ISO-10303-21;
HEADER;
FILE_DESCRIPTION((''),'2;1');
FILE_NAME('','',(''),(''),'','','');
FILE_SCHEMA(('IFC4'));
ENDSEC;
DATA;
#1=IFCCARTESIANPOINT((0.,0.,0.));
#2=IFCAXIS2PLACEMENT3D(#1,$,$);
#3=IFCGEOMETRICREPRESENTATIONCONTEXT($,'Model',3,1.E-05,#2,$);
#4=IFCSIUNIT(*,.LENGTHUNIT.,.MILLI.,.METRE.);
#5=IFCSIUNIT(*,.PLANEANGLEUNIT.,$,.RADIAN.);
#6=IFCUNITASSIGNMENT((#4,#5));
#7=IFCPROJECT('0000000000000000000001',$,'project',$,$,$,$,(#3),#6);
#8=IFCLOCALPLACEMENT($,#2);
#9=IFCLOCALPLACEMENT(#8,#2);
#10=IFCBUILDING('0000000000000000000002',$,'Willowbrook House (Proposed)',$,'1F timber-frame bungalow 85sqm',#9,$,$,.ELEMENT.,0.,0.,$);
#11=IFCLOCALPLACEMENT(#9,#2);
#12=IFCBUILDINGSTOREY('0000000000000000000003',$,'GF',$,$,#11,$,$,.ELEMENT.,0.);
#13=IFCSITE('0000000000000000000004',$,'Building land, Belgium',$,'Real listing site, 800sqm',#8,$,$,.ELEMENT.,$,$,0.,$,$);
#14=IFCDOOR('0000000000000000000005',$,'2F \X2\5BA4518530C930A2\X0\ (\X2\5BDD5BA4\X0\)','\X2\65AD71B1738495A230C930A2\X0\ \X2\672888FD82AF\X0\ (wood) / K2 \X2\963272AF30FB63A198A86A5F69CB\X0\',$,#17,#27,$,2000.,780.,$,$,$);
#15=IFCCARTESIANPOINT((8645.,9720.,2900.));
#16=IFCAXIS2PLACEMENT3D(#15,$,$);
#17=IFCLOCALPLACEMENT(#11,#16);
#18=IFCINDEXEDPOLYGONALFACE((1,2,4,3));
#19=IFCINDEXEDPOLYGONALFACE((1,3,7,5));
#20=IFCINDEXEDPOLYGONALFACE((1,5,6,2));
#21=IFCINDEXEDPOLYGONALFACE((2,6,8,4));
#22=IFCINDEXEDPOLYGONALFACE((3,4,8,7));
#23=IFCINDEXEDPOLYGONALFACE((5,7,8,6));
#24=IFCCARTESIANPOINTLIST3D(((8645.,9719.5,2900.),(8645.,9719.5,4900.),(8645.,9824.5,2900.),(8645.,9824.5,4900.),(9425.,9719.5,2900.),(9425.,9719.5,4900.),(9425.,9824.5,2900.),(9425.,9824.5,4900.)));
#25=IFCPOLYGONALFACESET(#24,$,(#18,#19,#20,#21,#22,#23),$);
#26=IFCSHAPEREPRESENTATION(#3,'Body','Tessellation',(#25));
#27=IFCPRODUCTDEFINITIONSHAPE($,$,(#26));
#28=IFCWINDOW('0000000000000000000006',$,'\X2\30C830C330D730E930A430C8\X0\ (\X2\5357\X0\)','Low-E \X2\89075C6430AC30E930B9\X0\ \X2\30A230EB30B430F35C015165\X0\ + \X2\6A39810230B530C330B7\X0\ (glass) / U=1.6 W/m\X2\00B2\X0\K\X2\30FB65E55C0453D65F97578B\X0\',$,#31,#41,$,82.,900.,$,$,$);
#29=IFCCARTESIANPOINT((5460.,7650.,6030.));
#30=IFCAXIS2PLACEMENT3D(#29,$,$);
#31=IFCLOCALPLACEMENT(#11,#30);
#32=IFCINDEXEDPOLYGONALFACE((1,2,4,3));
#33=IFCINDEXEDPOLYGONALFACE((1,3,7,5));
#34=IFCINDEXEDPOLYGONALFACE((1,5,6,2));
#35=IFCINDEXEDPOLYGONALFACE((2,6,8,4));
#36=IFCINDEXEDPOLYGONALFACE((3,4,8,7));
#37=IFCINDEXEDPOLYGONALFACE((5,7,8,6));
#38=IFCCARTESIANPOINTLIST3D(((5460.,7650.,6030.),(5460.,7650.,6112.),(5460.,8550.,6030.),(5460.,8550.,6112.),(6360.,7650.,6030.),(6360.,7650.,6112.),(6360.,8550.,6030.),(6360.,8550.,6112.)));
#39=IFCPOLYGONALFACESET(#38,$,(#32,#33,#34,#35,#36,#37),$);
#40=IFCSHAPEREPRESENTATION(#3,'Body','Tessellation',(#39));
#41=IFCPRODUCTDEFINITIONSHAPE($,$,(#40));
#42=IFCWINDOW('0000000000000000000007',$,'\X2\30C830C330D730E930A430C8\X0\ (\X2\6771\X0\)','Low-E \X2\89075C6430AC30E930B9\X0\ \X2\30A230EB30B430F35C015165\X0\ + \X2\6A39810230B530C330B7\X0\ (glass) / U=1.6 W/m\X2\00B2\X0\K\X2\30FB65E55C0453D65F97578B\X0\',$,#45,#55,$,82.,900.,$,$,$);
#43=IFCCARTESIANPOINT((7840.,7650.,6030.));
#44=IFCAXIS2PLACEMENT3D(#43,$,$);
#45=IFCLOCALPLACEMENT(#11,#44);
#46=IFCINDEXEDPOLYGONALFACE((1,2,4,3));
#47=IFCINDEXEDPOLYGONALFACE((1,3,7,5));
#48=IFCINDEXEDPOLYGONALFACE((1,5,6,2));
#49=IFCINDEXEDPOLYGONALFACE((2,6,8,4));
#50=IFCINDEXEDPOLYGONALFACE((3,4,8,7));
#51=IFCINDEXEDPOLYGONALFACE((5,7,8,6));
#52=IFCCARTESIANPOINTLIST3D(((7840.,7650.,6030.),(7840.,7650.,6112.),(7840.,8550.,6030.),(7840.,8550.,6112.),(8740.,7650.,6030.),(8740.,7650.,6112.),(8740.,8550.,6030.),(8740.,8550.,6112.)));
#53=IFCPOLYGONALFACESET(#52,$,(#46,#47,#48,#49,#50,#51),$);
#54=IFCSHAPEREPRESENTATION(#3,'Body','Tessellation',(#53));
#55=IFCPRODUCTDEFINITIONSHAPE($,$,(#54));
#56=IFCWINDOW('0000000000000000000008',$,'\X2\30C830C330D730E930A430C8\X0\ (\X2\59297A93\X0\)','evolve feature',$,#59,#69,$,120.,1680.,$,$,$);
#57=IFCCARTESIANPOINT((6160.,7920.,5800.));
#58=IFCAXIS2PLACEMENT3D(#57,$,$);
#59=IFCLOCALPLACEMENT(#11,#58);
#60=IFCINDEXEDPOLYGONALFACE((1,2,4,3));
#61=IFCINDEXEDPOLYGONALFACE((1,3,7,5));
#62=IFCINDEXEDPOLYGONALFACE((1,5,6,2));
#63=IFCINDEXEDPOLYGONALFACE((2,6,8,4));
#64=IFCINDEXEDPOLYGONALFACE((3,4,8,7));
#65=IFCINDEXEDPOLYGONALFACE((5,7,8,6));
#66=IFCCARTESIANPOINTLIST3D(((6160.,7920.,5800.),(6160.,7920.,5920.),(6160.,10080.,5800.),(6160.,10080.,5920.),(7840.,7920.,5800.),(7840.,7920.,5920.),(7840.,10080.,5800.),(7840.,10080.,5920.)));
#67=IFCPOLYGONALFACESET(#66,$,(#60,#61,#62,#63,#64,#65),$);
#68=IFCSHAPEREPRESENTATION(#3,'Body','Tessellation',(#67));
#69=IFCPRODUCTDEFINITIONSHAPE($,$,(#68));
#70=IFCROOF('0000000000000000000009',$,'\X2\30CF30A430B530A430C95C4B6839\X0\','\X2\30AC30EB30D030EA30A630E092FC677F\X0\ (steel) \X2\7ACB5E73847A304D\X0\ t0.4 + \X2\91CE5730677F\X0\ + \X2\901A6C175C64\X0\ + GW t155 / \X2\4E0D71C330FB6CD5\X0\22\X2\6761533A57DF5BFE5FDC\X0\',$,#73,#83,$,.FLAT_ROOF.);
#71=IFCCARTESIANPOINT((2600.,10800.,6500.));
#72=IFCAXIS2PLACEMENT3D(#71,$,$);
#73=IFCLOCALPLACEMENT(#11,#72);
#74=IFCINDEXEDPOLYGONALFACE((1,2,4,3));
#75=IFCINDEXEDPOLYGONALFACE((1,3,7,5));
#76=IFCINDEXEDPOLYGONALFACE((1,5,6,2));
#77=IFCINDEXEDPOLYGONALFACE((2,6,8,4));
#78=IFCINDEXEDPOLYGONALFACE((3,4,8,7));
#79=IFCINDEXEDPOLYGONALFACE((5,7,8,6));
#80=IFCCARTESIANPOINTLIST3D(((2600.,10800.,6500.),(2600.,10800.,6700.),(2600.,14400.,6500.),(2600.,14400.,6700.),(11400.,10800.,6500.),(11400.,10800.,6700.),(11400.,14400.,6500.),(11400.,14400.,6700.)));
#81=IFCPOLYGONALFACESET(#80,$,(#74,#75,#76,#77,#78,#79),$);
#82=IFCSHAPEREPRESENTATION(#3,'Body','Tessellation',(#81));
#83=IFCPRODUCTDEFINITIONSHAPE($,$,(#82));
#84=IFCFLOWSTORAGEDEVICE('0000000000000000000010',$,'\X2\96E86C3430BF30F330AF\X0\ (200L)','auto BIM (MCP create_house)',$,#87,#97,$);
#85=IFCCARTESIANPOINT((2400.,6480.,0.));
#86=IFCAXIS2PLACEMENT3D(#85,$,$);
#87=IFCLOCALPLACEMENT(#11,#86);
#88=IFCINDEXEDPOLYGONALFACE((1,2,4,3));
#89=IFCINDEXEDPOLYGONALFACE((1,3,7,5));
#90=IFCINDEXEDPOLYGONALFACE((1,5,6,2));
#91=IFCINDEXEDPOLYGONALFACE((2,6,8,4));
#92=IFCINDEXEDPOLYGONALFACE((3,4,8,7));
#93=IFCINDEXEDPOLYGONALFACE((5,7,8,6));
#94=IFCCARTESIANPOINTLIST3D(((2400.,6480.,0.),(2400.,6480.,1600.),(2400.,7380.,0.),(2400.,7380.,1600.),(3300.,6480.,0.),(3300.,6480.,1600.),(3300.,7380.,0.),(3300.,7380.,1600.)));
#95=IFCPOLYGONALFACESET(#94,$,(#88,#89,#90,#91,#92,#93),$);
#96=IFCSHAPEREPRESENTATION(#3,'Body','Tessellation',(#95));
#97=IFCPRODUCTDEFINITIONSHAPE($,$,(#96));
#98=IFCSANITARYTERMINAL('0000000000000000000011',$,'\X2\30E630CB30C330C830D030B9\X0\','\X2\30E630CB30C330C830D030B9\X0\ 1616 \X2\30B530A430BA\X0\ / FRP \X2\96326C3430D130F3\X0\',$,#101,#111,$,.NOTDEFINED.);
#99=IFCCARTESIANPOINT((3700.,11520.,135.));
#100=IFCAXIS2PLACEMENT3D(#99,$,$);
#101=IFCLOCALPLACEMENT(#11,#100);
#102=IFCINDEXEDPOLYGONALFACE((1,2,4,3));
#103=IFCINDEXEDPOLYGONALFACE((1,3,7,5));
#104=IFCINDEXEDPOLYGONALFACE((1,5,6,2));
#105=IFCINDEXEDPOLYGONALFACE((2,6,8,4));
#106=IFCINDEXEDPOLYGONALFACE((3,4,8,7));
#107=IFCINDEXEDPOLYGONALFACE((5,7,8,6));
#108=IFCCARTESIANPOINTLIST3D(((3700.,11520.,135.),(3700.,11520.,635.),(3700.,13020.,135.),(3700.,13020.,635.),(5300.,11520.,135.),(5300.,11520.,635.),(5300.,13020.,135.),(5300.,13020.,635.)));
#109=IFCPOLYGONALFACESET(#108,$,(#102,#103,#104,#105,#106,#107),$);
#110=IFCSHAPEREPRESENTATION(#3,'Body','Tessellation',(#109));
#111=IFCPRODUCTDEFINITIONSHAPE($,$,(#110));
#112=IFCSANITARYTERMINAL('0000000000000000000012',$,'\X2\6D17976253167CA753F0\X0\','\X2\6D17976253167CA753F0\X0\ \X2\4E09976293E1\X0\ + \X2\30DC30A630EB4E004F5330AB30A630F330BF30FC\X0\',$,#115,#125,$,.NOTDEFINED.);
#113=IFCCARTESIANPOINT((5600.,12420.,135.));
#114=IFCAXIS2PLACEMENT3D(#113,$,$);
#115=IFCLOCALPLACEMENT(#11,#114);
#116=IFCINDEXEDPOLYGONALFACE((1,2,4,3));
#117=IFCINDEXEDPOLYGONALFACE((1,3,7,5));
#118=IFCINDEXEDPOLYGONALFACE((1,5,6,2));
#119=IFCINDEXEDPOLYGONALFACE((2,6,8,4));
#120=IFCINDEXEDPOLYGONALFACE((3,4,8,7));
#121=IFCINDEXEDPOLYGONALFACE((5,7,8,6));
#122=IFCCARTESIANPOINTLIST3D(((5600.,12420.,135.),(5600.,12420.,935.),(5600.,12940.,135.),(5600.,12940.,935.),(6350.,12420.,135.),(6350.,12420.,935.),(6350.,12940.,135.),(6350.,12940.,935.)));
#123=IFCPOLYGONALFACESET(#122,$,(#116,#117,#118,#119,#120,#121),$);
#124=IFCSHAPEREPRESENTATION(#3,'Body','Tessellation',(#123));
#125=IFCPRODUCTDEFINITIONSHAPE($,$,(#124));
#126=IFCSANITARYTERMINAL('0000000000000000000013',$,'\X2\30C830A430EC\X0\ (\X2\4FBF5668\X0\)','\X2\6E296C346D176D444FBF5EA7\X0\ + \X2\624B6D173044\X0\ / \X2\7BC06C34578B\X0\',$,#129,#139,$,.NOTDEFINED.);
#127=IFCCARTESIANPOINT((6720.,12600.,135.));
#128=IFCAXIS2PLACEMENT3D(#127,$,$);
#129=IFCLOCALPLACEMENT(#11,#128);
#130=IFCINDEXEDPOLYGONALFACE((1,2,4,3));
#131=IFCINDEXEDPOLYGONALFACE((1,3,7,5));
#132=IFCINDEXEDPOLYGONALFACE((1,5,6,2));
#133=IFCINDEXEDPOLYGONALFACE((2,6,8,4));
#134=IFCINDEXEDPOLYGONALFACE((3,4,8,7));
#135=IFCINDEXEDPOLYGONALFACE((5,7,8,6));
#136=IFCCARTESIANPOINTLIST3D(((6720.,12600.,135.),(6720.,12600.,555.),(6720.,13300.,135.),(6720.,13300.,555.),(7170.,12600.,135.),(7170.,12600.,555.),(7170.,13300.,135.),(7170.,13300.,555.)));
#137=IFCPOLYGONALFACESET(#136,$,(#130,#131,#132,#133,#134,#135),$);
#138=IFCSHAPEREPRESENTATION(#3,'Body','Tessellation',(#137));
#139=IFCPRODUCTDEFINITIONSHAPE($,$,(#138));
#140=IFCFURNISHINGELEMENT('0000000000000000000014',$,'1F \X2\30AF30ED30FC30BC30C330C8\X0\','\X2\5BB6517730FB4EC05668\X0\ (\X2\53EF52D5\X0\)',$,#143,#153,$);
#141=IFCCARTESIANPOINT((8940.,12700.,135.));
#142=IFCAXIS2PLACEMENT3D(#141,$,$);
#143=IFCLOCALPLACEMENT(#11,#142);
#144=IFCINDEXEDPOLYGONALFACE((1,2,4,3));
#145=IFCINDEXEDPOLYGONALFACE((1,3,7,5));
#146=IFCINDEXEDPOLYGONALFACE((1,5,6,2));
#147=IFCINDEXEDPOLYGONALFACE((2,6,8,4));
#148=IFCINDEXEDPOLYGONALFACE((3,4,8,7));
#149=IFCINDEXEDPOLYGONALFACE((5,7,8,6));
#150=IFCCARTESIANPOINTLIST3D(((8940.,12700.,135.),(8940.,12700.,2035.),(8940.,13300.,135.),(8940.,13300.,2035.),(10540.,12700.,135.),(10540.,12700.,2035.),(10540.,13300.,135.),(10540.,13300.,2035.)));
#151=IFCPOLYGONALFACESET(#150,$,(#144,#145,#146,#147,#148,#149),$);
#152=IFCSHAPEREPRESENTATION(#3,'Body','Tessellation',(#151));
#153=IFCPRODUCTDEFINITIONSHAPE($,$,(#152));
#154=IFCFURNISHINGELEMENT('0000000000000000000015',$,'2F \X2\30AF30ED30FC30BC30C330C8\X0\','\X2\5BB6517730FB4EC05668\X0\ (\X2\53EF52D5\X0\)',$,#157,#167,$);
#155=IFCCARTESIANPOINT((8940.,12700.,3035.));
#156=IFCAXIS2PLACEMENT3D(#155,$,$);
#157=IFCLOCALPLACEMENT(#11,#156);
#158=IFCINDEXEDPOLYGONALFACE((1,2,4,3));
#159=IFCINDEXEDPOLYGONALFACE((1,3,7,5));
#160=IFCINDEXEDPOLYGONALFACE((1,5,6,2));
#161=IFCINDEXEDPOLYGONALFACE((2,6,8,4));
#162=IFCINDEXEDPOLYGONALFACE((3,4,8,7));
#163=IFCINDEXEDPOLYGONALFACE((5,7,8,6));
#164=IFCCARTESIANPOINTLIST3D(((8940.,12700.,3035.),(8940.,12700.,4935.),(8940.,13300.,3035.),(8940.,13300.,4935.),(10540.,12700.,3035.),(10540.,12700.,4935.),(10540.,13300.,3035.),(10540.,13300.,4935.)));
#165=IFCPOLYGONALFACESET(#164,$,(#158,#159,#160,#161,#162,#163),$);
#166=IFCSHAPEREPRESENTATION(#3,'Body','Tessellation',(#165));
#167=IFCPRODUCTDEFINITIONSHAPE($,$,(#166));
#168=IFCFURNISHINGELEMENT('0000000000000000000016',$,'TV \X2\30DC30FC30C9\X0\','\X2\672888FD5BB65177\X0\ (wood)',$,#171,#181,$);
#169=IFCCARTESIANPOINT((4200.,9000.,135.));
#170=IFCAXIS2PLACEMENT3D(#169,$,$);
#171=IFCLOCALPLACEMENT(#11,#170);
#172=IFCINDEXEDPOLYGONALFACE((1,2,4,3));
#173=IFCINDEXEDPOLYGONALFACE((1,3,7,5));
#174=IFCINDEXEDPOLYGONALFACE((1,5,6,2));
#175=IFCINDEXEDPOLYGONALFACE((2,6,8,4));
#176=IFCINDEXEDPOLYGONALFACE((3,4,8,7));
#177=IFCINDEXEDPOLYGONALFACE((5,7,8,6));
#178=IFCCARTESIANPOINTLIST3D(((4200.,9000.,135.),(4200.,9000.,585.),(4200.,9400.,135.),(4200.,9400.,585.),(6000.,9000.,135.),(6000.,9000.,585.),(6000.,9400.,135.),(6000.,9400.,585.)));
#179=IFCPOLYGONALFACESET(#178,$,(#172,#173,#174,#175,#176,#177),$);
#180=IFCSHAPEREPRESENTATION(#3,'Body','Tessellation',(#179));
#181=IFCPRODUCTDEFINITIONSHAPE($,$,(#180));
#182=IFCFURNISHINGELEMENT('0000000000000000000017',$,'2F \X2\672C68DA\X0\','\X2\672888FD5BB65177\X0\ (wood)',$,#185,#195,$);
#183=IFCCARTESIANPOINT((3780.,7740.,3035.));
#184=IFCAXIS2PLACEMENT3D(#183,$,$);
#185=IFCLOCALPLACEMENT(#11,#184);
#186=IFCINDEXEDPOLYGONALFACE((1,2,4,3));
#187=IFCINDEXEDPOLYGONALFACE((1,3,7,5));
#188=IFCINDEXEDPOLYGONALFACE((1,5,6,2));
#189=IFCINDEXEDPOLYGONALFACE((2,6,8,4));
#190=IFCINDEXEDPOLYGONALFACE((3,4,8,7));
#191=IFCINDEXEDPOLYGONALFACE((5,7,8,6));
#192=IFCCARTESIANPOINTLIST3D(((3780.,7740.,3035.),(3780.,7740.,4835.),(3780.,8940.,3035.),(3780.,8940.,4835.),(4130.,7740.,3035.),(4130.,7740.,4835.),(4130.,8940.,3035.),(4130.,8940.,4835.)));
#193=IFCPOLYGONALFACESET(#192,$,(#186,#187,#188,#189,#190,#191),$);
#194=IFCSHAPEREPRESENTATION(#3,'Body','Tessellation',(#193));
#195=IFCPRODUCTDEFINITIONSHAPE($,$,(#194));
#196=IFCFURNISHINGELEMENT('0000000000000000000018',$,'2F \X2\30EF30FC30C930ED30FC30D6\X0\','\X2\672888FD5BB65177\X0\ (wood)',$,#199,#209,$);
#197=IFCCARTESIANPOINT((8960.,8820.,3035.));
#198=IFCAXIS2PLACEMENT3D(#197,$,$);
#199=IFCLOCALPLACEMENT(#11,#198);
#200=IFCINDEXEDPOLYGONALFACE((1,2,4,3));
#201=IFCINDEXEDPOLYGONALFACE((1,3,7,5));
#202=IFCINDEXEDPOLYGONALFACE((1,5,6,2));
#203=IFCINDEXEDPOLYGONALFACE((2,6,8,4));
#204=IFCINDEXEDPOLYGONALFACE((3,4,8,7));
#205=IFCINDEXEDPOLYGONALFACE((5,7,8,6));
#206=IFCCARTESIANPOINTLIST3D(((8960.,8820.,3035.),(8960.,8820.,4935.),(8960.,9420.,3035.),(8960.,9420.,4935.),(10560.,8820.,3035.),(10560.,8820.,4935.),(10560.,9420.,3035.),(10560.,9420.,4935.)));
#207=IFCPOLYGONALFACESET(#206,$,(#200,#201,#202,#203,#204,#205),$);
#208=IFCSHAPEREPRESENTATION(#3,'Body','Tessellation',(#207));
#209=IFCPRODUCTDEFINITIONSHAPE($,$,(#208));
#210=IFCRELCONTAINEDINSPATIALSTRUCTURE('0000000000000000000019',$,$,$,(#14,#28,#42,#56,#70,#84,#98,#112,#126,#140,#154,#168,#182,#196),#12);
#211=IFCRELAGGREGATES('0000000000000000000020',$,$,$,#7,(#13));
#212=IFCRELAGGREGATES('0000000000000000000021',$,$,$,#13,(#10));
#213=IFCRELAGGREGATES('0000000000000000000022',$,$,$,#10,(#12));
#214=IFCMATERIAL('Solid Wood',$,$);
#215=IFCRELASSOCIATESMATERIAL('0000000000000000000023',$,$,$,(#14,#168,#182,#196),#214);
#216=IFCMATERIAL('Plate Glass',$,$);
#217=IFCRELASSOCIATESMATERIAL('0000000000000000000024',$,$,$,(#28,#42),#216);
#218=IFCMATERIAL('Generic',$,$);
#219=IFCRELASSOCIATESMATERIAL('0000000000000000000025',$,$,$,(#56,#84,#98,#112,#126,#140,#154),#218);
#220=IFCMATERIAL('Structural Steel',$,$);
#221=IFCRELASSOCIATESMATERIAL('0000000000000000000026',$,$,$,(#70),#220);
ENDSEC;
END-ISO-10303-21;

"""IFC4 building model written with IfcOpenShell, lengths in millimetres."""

from ifc_helpers import new_model, si_unit, frame, frame_2d, origin, place, context, project, spatial, rectangle, extrude, material, element, save


model = new_model("IFC4")

# Units and contexts
model_context = context("Model", 3, precision=1e-05, world=origin())
ifc_project = project(units=[si_unit("LENGTHUNIT", "METRE", prefix="MILLI"), si_unit("PLANEANGLEUNIT", "RADIAN")], contexts=[model_context])

# Site, building, storey
site_placement = place(None, origin())
site = spatial("IfcSite", under=ifc_project, at=site_placement, Name="Building land, Belgium", ObjectType="Real listing site, 800sqm", CompositionType="ELEMENT", RefElevation=0.0)
building_placement = place(site_placement, origin())
building = spatial("IfcBuilding", under=site, at=building_placement, Name="Willowbrook House (Proposed)", ObjectType="1F timber-frame bungalow 85sqm", CompositionType="ELEMENT", ElevationOfRefHeight=0.0, ElevationOfTerrain=0.0)
storey_placement = place(building_placement, origin())
storey = spatial("IfcBuildingStorey", under=building, at=storey_placement, Name="GF", CompositionType="ELEMENT", Elevation=0.0)

# Shared definitions
ifc_material_1 = material(Name="Solid Wood")
ifc_material_2 = material(Name="Plate Glass")

# Door
door_1_placement = place(storey_placement, frame((8645.0, 9720.0, 2900.0)))
element("IfcDoor", 1, at=door_1_placement, inside=storey, material=ifc_material_1, Name="2F 室内ドア (寝室)", Description="断熱玄関ドア 木製芯 (wood) / K2 防犯・採風機構", OverallHeight=2000.0, OverallWidth=780.0, context=model_context, shape_type="SweptSolid", body=[
    extrude(rectangle(XDim=780.0, YDim=105.0, at=frame_2d((390.0, 52.0))), frame((8645.0, 9720.0, 2900.0)), (0.0, 0.0, 1.0), 2000.0),
])

# Windows
window_1_placement = place(storey_placement, frame((5460.0, 7650.0, 6030.0)))
element("IfcWindow", 2, at=window_1_placement, inside=storey, material=ifc_material_2, Name="トップライト (南)", Description="Low-E 複層ガラス アルゴン封入 + 樹脂サッシ (glass) / U=1.6 W/m²K・日射取得型", OverallHeight=82.0, OverallWidth=900.0, context=model_context, shape_type="SweptSolid", body=[
    extrude(rectangle(XDim=900.0, YDim=900.0, at=frame_2d((450.0, 450.0))), frame((5460.0, 7650.0, 6030.0)), (0.0, 0.0, 1.0), 82.0),
])
window_2_placement = place(storey_placement, frame((7840.0, 7650.0, 6030.0)))
element("IfcWindow", 3, at=window_2_placement, inside=storey, material=ifc_material_2, Name="トップライト (東)", Description="Low-E 複層ガラス アルゴン封入 + 樹脂サッシ (glass) / U=1.6 W/m²K・日射取得型", OverallHeight=82.0, OverallWidth=900.0, context=model_context, shape_type="SweptSolid", body=[
    extrude(rectangle(XDim=900.0, YDim=900.0, at=frame_2d((450.0, 450.0))), frame((7840.0, 7650.0, 6030.0)), (0.0, 0.0, 1.0), 82.0),
])
ifc_material_3 = material(Name="Generic")
window_3_placement = place(storey_placement, frame((6160.0, 7920.0, 5800.0)))
element("IfcWindow", 4, at=window_3_placement, inside=storey, material=ifc_material_3, Name="トップライト (天窓)", Description="evolve feature", OverallHeight=120.0, OverallWidth=1680.0, context=model_context, shape_type="SweptSolid", body=[
    extrude(rectangle(XDim=1680.0, YDim=2160.0, at=frame_2d((840.0, 1080.0))), frame((6160.0, 7920.0, 5800.0)), (0.0, 0.0, 1.0), 120.0),
])

# Roof
ifc_material_4 = material(Name="Structural Steel")
roof_placement = place(storey_placement, frame((2600.0, 10800.0, 6500.0)))
element("IfcRoof", 5, at=roof_placement, inside=storey, material=ifc_material_4, Name="ハイサイド屋根", Description="ガルバリウム鋼板 (steel) 立平葺き t0.4 + 野地板 + 通気層 + GW t155 / 不燃・法22条区域対応", PredefinedType="FLAT_ROOF", context=model_context, shape_type="SweptSolid", body=[
    extrude(rectangle(XDim=8800.0, YDim=3600.0, at=frame_2d((4400.0, 1800.0))), frame((2600.0, 10800.0, 6500.0)), (0.0, 0.0, 1.0), 200.0),
])

# Flow storage device
flow_storage_device_placement = place(storey_placement, frame((2400.0, 6480.0, 0.0)))
element("IfcFlowStorageDevice", 6, at=flow_storage_device_placement, inside=storey, material=ifc_material_3, Name="雨水タンク (200L)", Description="auto BIM (MCP create_house)", context=model_context, shape_type="SweptSolid", body=[
    extrude(rectangle(XDim=900.0, YDim=900.0, at=frame_2d((450.0, 450.0))), frame((2400.0, 6480.0, 0.0)), (0.0, 0.0, 1.0), 1600.0),
])

# Sanitary terminals
sanitary_terminal_1_placement = place(storey_placement, frame((3700.0, 11520.0, 135.0)))
element("IfcSanitaryTerminal", 7, at=sanitary_terminal_1_placement, inside=storey, material=ifc_material_3, Name="ユニットバス", Description="ユニットバス 1616 サイズ / FRP 防水パン", PredefinedType="NOTDEFINED", context=model_context, shape_type="SweptSolid", body=[
    extrude(rectangle(XDim=1600.0, YDim=1500.0, at=frame_2d((800.0, 750.0))), frame((3700.0, 11520.0, 135.0)), (0.0, 0.0, 1.0), 500.0),
])
sanitary_terminal_2_placement = place(storey_placement, frame((5600.0, 12420.0, 135.0)))
element("IfcSanitaryTerminal", 8, at=sanitary_terminal_2_placement, inside=storey, material=ifc_material_3, Name="洗面化粧台", Description="洗面化粧台 三面鏡 + ボウル一体カウンター", PredefinedType="NOTDEFINED", context=model_context, shape_type="SweptSolid", body=[
    extrude(rectangle(XDim=750.0, YDim=520.0, at=frame_2d((375.0, 260.0))), frame((5600.0, 12420.0, 135.0)), (0.0, 0.0, 1.0), 800.0),
])
sanitary_terminal_3_placement = place(storey_placement, frame((6720.0, 12600.0, 135.0)))
element("IfcSanitaryTerminal", 9, at=sanitary_terminal_3_placement, inside=storey, material=ifc_material_3, Name="トイレ (便器)", Description="温水洗浄便座 + 手洗い / 節水型", PredefinedType="NOTDEFINED", context=model_context, shape_type="SweptSolid", body=[
    extrude(rectangle(XDim=450.0, YDim=700.0, at=frame_2d((225.0, 350.0))), frame((6720.0, 12600.0, 135.0)), (0.0, 0.0, 1.0), 420.0),
])

# Furnishing elements
furnishing_1_placement = place(storey_placement, frame((8940.0, 12700.0, 135.0)))
element("IfcFurnishingElement", 10, at=furnishing_1_placement, inside=storey, material=ifc_material_3, Name="1F クローゼット", Description="家具・什器 (可動)", context=model_context, shape_type="SweptSolid", body=[
    extrude(rectangle(XDim=1600.0, YDim=600.0, at=frame_2d((800.0, 300.0))), frame((8940.0, 12700.0, 135.0)), (0.0, 0.0, 1.0), 1900.0),
])
furnishing_2_placement = place(storey_placement, frame((8940.0, 12700.0, 3035.0)))
element("IfcFurnishingElement", 11, at=furnishing_2_placement, inside=storey, material=ifc_material_3, Name="2F クローゼット", Description="家具・什器 (可動)", context=model_context, shape_type="SweptSolid", body=[
    extrude(rectangle(XDim=1600.0, YDim=600.0, at=frame_2d((800.0, 300.0))), frame((8940.0, 12700.0, 3035.0)), (0.0, 0.0, 1.0), 1900.0),
])
furnishing_3_placement = place(storey_placement, frame((4200.0, 9000.0, 135.0)))
element("IfcFurnishingElement", 12, at=furnishing_3_placement, inside=storey, material=ifc_material_1, Name="TV ボード", Description="木製家具 (wood)", context=model_context, shape_type="SweptSolid", body=[
    extrude(rectangle(XDim=1800.0, YDim=400.0, at=frame_2d((900.0, 200.0))), frame((4200.0, 9000.0, 135.0)), (0.0, 0.0, 1.0), 450.0),
])
furnishing_4_placement = place(storey_placement, frame((3780.0, 7740.0, 3035.0)))
element("IfcFurnishingElement", 13, at=furnishing_4_placement, inside=storey, material=ifc_material_1, Name="2F 本棚", Description="木製家具 (wood)", context=model_context, shape_type="SweptSolid", body=[
    extrude(rectangle(XDim=350.0, YDim=1200.0, at=frame_2d((175.0, 600.0))), frame((3780.0, 7740.0, 3035.0)), (0.0, 0.0, 1.0), 1800.0),
])
furnishing_5_placement = place(storey_placement, frame((8960.0, 8820.0, 3035.0)))
element("IfcFurnishingElement", 14, at=furnishing_5_placement, inside=storey, material=ifc_material_1, Name="2F ワードローブ", Description="木製家具 (wood)", context=model_context, shape_type="SweptSolid", body=[
    extrude(rectangle(XDim=1600.0, YDim=600.0, at=frame_2d((800.0, 300.0))), frame((8960.0, 8820.0, 3035.0)), (0.0, 0.0, 1.0), 1900.0),
])

save(model, "model.ifc")
